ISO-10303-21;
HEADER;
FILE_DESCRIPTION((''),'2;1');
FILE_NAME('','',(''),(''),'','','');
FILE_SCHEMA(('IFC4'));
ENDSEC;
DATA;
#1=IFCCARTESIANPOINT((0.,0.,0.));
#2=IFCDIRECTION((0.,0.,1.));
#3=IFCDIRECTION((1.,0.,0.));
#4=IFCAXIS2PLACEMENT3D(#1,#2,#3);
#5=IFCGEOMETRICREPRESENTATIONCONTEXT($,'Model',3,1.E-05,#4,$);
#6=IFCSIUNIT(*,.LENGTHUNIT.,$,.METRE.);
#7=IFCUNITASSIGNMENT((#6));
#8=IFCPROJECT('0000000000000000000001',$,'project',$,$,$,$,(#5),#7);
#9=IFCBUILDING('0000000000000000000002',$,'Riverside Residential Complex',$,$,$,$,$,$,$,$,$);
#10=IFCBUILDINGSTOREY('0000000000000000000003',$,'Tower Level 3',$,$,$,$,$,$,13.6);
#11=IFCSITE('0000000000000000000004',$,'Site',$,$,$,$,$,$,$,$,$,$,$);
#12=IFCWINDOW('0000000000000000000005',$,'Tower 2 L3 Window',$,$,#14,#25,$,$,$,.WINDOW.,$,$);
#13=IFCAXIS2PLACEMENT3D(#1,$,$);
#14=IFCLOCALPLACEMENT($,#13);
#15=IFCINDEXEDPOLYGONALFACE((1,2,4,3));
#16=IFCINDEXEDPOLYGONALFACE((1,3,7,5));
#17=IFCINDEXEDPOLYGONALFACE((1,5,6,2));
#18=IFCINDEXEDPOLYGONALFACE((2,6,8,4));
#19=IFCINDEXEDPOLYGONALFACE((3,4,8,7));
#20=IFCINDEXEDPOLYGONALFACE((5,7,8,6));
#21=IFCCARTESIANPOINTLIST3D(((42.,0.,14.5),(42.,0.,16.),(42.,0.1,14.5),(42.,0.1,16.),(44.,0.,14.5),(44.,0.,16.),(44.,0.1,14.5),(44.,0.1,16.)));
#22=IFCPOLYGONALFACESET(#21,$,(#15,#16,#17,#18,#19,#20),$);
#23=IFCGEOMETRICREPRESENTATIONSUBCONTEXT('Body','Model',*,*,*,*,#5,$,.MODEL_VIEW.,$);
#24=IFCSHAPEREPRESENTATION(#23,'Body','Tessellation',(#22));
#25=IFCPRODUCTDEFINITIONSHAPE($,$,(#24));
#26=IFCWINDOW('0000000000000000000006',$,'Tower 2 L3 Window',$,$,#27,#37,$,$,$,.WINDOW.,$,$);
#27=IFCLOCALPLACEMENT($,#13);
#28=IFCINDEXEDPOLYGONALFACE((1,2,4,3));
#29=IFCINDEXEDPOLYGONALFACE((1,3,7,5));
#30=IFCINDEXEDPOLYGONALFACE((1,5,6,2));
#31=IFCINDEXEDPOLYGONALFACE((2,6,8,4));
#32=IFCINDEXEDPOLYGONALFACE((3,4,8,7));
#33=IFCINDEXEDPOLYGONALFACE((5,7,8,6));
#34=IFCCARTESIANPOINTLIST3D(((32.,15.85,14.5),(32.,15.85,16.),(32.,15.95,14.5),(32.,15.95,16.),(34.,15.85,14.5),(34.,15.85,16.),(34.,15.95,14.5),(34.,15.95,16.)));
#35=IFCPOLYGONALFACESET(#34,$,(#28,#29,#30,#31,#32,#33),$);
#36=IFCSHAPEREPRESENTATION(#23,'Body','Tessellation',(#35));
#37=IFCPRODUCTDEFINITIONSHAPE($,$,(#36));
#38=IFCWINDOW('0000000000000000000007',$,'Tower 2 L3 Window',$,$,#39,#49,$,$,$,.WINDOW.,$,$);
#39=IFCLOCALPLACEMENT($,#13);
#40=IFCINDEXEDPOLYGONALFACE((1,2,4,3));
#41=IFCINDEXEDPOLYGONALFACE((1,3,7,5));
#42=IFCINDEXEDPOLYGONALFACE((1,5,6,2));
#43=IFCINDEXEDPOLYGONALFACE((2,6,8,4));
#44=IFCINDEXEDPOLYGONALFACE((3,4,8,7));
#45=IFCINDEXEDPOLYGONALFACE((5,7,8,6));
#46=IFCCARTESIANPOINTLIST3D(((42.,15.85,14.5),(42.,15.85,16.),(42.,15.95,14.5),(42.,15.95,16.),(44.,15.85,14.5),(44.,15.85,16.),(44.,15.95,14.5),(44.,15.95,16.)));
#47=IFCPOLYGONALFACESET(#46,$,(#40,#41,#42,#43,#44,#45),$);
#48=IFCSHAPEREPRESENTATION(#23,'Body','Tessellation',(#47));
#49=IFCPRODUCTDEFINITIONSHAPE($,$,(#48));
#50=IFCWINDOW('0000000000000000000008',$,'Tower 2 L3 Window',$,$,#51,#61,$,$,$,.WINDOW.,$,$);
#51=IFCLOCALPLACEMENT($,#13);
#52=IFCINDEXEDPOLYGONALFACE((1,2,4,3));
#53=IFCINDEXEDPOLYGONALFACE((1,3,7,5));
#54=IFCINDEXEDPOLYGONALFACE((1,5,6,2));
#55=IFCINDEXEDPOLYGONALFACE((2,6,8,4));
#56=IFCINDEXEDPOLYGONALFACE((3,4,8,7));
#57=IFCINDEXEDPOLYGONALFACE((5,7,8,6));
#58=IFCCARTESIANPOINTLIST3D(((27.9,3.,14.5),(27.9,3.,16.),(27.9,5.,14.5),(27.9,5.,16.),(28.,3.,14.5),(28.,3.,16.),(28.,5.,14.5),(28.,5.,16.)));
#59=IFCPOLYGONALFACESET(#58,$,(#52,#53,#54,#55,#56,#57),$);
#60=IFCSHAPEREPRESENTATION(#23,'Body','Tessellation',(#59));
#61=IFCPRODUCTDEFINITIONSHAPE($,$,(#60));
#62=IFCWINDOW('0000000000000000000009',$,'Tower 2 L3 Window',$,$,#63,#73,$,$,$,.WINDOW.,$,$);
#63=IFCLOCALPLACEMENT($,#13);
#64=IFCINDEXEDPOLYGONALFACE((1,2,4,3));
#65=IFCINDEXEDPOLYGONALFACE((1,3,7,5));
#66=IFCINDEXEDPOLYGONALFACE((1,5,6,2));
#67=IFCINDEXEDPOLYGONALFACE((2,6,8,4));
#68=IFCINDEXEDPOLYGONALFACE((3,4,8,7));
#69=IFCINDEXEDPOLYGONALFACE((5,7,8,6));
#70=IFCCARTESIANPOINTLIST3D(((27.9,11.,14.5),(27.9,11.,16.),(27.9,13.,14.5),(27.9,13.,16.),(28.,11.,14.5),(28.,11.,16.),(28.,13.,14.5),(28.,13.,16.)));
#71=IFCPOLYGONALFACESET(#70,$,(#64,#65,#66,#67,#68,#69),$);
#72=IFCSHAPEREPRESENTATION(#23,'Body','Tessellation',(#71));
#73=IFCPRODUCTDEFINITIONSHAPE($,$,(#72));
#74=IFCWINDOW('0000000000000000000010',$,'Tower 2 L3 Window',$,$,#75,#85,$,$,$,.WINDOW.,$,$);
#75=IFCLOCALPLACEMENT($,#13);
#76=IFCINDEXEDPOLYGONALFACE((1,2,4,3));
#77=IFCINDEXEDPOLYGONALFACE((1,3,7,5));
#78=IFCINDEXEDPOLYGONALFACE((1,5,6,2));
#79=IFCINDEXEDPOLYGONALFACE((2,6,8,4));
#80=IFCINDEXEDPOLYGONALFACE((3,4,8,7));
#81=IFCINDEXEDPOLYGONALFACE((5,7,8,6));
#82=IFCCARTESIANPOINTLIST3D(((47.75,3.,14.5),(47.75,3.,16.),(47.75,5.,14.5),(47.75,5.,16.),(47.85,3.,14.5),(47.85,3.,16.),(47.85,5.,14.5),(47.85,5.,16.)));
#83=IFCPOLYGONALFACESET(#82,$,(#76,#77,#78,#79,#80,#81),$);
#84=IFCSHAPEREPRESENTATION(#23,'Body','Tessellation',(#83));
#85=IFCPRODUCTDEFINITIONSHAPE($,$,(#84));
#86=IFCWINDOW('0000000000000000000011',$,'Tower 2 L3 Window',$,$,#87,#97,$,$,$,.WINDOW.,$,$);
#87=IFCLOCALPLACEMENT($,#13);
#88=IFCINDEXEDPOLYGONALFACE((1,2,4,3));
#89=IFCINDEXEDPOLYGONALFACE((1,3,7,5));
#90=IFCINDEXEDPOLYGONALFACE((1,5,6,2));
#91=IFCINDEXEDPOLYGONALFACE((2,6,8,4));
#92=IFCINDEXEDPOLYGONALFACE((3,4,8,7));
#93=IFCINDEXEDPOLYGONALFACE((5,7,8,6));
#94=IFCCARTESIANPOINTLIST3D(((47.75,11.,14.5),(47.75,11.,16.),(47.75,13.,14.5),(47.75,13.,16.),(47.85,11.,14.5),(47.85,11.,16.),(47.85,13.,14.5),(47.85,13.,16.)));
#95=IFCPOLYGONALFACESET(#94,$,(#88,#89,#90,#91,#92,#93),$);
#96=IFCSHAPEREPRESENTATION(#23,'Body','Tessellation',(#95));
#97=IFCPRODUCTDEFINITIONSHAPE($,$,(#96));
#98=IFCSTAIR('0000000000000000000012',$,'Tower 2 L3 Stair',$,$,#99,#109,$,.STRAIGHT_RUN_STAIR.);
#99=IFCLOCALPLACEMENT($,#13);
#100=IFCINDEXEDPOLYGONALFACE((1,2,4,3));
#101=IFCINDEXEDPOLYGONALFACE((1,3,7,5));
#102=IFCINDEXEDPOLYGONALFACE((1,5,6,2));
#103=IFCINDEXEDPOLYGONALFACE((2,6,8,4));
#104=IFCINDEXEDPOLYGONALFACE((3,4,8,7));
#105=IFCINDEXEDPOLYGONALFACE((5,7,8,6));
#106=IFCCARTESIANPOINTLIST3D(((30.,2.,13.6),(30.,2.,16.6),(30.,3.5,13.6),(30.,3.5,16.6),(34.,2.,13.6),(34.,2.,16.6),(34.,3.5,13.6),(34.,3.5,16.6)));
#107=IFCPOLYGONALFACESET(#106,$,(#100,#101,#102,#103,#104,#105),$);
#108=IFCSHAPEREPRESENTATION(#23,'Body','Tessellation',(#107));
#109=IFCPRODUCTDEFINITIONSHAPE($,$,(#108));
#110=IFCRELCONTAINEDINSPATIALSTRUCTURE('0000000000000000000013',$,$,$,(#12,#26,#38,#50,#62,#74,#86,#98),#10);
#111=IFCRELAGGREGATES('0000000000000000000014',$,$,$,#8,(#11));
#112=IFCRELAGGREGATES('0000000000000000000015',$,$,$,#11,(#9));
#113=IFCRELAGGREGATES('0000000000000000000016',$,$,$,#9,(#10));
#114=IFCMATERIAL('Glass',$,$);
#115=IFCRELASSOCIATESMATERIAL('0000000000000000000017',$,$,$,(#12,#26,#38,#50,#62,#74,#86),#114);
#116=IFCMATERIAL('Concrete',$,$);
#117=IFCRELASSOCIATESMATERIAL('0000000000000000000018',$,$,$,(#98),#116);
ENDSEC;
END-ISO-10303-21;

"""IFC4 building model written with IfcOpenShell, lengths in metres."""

from ifc_helpers import new_model, si_unit, frame, origin_with_axes, place, context, subcontext, project, spatial, line, indexed_curve, outline, extrude, material, element, save


model = new_model("IFC4")

# Units and contexts
model_context = context("Model", 3, precision=1e-05, world=origin_with_axes())
body_context = subcontext(model_context, "Body", "Model", "MODEL_VIEW")
ifc_project = project(units=[si_unit("LENGTHUNIT", "METRE")], contexts=[model_context])

# Site, building, storey
site = spatial("IfcSite", under=ifc_project, Name="Site")
building = spatial("IfcBuilding", under=site, Name="Riverside Residential Complex")
storey = spatial("IfcBuildingStorey", under=building, Name="Tower Level 3", Elevation=13.6)

# Shared definitions
ifc_material_1 = material(Name="Concrete")

# Windows
ifc_material_2 = material(Name="Glass")
for number, where, z_axis, x_axis, name in (
    (1, (42.0, 0.0, 14.5), (0.0, 0.0, 1.0), (1.0, 0.0, 0.0), "Tower 2 L3 Window"),
    (2, (32.0, 15.85, 14.5), (0.0, 0.0, 1.0), (1.0, 0.0, 0.0), "Tower 2 L3 Window"),
    (3, (42.0, 15.85, 14.5), (0.0, 0.0, 1.0), (1.0, 0.0, 0.0), "Tower 2 L3 Window"),
    (4, (28.0, 3.0, 14.5), (0.0, 0.0, 1.0), (0.0, 1.0, 0.0), "Tower 2 L3 Window"),
    (5, (28.0, 11.0, 14.5), (0.0, 0.0, 1.0), (0.0, 1.0, 0.0), "Tower 2 L3 Window"),
    (6, (47.85, 3.0, 14.5), (0.0, 0.0, 1.0), (0.0, 1.0, 0.0), "Tower 2 L3 Window"),
    (7, (47.85, 11.0, 14.5), (0.0, 0.0, 1.0), (0.0, 1.0, 0.0), "Tower 2 L3 Window"),
):
    element("IfcWindow", number, at=place(None, frame(where, z_axis=z_axis, x_axis=x_axis)), inside=storey, material=ifc_material_2, Name=name, PredefinedType="WINDOW", context=body_context, shape_type="SweptSolid", body=[
        extrude(outline(indexed_curve([(0.0, 0.0), (2.0, 0.0), (2.0, 0.1), (0.0, 0.1)], segments=[line(1, 2, 3, 4, 1)])), origin_with_axes(), (0.0, 0.0, 1.0), 1.5),
    ])

# Stair
stair_placement = place(None, frame((30.0, 2.0, 13.6), z_axis=(0.0, 0.0, 1.0), x_axis=(1.0, 0.0, 0.0)))
element("IfcStair", 8, at=stair_placement, inside=storey, material=ifc_material_1, Name="Tower 2 L3 Stair", PredefinedType="STRAIGHT_RUN_STAIR", context=body_context, shape_type="SweptSolid", body=[
    extrude(outline(indexed_curve([(0.0, 0.0), (4.0, 0.0), (4.0, 1.5), (0.0, 1.5)], segments=[line(1, 2, 3, 4, 1)])), origin_with_axes(), (0.0, 0.0, 1.0), 3.0),
])

save(model, "model.ifc")
